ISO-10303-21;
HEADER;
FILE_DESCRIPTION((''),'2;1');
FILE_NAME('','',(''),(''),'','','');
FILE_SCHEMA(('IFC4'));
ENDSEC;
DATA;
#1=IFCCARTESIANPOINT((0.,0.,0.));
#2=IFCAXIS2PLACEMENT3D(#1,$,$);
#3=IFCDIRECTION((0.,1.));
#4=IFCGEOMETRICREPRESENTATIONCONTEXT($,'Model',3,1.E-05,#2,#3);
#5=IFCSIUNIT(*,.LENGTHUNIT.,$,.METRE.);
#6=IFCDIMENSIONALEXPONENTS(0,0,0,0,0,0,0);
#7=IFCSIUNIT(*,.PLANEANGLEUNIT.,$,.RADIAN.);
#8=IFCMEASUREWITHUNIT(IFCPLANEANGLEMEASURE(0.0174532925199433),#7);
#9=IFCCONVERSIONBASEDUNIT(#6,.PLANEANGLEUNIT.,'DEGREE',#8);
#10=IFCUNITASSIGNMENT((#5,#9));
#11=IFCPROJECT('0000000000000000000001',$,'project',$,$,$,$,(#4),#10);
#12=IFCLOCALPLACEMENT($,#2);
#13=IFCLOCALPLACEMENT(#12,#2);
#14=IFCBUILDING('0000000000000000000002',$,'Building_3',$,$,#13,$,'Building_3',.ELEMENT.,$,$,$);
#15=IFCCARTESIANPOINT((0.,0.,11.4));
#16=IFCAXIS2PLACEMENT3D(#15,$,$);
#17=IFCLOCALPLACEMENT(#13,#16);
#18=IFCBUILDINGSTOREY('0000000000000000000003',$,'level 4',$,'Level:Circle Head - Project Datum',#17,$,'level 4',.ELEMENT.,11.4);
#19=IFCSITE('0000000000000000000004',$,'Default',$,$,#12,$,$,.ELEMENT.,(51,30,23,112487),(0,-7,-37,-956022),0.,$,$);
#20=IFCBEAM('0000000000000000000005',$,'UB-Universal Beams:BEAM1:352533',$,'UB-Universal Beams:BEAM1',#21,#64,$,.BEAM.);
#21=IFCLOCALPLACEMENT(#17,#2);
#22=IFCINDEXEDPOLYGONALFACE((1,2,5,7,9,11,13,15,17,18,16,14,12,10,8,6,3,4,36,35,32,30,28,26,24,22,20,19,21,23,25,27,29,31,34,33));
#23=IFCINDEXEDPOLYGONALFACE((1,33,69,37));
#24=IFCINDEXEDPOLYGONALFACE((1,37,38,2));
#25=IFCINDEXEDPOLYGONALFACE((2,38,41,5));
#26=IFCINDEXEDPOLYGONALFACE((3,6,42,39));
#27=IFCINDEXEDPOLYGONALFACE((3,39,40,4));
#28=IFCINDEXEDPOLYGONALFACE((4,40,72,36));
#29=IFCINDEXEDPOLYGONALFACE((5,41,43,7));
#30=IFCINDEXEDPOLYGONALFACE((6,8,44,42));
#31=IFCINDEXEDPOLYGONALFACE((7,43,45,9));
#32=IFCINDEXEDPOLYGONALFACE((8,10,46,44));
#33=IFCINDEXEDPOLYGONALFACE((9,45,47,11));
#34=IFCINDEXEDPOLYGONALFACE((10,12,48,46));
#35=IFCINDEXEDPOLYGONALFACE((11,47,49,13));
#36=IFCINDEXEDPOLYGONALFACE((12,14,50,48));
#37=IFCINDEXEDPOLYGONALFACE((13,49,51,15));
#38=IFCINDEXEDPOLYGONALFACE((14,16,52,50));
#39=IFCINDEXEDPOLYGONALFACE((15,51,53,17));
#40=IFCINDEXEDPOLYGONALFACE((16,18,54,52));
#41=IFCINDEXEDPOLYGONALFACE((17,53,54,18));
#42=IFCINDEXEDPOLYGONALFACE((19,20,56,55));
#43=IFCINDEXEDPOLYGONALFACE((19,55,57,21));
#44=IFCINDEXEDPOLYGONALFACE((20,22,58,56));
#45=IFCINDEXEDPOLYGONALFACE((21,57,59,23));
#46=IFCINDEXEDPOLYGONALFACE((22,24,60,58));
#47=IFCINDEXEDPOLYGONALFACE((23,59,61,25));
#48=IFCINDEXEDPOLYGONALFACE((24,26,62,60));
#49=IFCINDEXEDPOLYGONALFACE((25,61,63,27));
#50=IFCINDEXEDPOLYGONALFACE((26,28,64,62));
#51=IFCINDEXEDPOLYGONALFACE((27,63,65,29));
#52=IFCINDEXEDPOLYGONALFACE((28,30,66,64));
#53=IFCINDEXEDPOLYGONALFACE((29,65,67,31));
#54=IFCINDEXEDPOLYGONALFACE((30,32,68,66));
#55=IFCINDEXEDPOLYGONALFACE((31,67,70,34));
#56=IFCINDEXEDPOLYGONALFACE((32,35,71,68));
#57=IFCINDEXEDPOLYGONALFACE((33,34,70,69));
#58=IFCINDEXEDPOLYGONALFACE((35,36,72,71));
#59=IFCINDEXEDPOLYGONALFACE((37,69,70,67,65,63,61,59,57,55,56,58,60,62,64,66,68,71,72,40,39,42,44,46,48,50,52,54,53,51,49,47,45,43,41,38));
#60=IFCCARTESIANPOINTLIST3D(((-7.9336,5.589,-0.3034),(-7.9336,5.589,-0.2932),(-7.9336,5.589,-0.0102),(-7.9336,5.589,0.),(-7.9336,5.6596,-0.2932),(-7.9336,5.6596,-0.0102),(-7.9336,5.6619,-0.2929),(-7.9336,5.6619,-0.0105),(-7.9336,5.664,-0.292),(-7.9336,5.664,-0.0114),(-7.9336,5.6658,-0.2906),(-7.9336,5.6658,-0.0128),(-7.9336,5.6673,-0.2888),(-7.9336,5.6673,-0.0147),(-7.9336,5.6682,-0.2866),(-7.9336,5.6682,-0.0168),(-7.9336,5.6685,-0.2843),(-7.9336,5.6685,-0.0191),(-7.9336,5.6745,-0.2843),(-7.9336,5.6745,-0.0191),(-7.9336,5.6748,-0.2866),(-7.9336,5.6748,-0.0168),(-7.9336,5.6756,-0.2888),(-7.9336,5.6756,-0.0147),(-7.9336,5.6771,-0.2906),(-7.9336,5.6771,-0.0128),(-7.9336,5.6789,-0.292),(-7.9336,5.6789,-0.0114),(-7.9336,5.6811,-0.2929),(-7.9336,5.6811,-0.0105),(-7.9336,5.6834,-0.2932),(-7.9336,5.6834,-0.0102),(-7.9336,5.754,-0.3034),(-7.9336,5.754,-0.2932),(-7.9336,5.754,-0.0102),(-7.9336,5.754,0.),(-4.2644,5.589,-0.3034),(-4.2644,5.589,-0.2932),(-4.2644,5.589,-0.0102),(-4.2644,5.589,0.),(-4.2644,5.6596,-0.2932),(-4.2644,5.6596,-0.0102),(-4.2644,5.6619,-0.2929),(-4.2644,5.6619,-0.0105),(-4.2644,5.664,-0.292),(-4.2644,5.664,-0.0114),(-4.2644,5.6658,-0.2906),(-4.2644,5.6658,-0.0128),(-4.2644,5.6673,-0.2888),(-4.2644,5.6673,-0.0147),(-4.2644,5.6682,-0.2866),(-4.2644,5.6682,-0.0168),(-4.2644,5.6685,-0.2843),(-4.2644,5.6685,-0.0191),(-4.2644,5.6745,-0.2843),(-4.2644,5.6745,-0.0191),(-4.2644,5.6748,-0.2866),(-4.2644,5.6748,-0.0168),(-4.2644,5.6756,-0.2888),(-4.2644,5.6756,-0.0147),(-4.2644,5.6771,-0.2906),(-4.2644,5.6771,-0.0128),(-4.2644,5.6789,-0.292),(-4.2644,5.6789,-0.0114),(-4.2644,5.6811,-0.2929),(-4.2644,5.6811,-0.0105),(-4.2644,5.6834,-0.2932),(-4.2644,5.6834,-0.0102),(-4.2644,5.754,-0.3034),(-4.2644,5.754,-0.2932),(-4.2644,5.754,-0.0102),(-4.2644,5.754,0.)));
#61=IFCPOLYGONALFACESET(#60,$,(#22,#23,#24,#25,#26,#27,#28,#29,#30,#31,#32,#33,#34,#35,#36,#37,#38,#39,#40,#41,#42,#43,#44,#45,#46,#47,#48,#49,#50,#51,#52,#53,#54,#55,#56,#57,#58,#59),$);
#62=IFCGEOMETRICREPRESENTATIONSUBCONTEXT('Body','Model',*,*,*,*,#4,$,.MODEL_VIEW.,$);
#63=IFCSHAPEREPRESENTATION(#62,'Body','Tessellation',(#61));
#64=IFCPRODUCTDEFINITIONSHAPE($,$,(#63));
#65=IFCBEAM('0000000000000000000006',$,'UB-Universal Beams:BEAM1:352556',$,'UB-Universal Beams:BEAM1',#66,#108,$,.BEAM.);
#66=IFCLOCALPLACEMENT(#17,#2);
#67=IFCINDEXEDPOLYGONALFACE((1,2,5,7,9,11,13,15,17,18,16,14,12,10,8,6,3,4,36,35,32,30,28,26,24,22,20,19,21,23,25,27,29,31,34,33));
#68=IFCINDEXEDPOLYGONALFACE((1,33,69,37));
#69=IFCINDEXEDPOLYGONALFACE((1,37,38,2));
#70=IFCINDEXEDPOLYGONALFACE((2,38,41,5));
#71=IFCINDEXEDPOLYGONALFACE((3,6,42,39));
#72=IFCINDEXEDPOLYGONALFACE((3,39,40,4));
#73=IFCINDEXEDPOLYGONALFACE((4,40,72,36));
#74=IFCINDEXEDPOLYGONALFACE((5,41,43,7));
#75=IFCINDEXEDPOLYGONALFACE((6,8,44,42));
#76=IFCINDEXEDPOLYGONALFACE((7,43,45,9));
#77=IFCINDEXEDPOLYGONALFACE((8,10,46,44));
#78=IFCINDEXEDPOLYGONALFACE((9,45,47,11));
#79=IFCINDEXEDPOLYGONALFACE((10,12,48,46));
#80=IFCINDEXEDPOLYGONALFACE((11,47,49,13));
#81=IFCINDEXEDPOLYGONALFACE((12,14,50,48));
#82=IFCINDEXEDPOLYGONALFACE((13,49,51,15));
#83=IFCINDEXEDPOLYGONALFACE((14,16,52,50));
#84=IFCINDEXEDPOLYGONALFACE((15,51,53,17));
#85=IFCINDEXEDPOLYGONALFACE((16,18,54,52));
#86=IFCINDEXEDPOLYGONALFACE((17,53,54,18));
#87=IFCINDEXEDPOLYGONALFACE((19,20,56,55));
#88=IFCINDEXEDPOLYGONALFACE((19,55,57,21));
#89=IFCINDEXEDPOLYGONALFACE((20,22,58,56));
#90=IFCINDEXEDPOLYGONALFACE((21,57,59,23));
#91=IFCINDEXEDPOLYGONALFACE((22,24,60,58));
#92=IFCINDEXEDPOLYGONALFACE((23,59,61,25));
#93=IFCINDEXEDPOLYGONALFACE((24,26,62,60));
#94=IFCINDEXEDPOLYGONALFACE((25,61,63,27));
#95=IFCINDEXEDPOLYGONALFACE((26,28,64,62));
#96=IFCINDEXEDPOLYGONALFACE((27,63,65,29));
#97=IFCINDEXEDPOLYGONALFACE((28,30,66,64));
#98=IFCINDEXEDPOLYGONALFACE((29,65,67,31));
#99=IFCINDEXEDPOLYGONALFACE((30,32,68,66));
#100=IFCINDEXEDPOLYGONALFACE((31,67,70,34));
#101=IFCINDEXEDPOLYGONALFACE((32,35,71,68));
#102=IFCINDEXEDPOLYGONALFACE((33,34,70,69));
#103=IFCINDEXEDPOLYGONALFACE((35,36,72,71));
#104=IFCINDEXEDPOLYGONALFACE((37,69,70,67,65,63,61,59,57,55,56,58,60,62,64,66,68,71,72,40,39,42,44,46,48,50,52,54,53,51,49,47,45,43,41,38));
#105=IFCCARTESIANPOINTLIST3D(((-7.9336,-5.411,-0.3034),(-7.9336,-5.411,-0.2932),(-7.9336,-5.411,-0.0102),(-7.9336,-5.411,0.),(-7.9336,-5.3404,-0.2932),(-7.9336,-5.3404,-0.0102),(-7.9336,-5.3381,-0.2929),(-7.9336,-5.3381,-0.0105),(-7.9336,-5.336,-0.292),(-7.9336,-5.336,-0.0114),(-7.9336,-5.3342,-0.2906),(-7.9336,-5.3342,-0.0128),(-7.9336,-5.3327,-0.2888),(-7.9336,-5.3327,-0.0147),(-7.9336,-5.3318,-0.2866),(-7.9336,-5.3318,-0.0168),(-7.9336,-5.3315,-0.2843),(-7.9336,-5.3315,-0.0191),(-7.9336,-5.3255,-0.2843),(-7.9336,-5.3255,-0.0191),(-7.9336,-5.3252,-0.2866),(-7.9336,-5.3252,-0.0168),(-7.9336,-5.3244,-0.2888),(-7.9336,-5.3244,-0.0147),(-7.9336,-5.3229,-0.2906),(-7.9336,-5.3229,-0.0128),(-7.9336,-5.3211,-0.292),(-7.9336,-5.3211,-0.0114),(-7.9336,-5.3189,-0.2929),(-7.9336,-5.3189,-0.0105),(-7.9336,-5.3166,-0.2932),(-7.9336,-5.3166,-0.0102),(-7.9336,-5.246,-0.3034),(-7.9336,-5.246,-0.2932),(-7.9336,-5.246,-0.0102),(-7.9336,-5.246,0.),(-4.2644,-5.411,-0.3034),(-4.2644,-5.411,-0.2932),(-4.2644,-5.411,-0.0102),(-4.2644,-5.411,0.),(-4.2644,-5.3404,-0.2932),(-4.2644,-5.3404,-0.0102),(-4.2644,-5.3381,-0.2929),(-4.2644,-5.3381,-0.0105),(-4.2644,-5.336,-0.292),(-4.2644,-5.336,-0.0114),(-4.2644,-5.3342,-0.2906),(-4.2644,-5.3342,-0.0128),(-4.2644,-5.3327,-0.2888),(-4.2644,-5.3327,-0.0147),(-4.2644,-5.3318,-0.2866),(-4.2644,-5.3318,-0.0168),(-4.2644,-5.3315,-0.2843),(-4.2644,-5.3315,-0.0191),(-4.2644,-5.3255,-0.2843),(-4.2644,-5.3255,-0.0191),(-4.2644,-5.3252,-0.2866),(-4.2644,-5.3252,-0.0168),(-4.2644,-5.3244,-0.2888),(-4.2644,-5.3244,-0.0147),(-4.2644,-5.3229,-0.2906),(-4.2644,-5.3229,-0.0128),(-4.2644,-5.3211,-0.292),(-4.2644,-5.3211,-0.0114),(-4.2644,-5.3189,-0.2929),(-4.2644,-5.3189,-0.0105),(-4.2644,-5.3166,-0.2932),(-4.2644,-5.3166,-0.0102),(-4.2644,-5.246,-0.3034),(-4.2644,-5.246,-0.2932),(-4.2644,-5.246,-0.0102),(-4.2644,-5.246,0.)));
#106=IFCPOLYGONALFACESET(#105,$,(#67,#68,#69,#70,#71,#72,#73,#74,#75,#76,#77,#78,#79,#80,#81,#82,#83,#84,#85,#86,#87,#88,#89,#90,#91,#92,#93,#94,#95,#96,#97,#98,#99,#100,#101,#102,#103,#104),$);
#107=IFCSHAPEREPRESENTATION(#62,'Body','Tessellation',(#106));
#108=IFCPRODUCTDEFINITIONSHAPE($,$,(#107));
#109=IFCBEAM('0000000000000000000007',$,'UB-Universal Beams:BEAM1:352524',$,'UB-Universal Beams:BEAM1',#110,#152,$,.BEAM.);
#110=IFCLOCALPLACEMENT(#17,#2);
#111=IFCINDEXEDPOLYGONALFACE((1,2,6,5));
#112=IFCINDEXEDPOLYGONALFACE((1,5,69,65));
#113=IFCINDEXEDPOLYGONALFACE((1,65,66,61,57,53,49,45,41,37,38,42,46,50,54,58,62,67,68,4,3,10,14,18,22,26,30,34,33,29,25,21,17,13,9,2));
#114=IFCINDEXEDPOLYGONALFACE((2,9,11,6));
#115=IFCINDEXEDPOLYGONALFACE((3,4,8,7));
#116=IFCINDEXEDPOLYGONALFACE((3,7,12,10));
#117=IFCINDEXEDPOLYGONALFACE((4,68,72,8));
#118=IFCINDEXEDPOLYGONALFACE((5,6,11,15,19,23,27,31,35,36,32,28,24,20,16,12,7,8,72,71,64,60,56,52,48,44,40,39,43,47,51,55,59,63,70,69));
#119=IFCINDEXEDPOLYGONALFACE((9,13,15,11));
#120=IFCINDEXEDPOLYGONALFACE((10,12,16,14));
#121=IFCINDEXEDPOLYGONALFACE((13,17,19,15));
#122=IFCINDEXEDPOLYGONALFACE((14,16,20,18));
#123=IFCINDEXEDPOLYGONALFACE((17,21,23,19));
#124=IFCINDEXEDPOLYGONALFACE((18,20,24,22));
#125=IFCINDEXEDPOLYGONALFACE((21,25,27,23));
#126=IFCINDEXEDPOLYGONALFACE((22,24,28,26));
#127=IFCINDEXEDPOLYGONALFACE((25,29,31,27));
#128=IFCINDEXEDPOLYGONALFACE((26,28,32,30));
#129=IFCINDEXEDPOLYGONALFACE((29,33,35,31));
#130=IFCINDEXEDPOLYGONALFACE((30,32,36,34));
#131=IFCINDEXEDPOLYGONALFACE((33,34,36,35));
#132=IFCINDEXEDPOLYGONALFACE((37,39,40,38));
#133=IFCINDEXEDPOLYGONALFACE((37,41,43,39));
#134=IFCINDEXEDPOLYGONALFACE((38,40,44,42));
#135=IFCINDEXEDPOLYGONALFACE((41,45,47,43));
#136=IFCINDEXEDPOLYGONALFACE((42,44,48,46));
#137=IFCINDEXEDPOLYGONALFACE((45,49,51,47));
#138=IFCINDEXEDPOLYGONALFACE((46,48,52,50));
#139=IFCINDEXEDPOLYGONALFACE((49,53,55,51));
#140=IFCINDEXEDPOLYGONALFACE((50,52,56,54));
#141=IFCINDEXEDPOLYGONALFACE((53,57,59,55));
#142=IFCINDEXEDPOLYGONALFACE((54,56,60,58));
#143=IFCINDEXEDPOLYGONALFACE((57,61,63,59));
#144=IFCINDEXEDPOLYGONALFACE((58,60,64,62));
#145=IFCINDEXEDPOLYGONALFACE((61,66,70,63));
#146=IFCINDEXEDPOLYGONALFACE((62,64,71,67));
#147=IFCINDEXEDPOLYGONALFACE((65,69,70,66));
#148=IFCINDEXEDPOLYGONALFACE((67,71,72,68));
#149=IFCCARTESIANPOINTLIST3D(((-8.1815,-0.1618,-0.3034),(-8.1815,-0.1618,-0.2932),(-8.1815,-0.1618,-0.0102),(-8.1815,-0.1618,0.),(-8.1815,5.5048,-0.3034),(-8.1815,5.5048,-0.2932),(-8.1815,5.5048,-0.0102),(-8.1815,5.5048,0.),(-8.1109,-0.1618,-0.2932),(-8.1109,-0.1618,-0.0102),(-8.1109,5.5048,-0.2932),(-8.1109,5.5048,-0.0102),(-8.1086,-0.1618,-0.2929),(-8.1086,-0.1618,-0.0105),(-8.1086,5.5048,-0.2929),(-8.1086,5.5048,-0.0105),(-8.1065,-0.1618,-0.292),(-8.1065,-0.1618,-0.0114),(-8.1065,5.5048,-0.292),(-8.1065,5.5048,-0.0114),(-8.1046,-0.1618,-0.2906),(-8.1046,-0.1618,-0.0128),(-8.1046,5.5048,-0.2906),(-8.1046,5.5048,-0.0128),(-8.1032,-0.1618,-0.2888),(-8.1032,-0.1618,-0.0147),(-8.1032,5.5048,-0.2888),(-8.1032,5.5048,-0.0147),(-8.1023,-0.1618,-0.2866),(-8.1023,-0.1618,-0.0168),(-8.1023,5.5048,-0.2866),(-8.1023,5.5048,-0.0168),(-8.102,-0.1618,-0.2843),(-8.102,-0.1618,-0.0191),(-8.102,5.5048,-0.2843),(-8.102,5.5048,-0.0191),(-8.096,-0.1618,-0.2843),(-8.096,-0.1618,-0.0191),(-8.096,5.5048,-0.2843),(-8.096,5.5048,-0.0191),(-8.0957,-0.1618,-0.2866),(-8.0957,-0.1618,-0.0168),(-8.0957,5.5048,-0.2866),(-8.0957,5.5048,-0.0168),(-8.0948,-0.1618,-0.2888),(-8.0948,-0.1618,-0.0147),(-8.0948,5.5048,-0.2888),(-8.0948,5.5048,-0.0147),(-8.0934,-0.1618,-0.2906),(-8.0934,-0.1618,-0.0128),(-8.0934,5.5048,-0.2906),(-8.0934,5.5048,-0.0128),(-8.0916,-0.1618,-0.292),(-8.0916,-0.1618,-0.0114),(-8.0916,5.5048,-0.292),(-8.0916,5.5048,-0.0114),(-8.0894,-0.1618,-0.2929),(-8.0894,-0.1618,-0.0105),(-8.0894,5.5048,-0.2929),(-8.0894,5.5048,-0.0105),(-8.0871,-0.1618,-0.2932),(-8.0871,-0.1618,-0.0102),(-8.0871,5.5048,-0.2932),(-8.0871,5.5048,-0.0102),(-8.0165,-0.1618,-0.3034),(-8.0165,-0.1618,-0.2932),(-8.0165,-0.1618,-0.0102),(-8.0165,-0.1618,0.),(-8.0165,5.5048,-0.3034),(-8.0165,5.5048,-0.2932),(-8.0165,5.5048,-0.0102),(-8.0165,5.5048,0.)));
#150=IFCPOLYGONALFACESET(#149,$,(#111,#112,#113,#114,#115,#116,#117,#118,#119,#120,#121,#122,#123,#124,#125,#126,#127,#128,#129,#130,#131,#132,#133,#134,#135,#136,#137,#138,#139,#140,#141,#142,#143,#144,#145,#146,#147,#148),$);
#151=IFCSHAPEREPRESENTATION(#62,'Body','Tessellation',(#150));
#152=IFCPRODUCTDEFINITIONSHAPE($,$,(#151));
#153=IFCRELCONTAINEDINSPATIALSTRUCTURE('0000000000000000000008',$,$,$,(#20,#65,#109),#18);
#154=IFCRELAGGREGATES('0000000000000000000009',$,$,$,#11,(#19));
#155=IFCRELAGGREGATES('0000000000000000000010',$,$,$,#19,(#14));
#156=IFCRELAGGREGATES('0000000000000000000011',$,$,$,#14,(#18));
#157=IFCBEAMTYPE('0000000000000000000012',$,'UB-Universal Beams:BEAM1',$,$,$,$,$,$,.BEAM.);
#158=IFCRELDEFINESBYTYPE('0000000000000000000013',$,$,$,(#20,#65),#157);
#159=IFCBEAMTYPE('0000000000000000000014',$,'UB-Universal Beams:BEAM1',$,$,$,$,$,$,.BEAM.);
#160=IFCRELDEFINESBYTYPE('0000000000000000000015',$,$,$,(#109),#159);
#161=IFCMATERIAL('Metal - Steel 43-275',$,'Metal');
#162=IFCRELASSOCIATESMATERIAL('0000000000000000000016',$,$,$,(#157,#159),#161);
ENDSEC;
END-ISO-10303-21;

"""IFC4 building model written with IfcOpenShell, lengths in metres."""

from ifc_helpers import new_model, entity, si_unit, converted_unit, direction, frame, frame_2d, origin, place, context, subcontext, project, spatial, polyline, circle_curve, parameter, trimmed, segment, composite_curve, outline, extrude, source, transform, mapped, material, material_profile, profile_set, type_object, type_shapes, element, save


model = new_model("IFC4")

# Units and contexts
model_context = context("Model", 3, precision=1e-05, world=origin(), true_north=direction((0.0, 1.0)))
body_context = subcontext(model_context, "Body", "Model", "MODEL_VIEW")
ifc_project = project(units=[si_unit("LENGTHUNIT", "METRE"), converted_unit("PLANEANGLEUNIT", "DEGREE", entity("IfcPlaneAngleMeasure", 0.0174532925199433), si_unit("PLANEANGLEUNIT", "RADIAN"), dimensions=[0, 0, 0, 0, 0, 0, 0])], contexts=[model_context])

# Site, building, storey
site_placement = place(None, origin())
site = spatial("IfcSite", under=ifc_project, at=site_placement, Name="Default", CompositionType="ELEMENT", RefLatitude=(51, 30, 23, 112487), RefLongitude=(0, -7, -37, -956022), RefElevation=0.0)
building_placement = place(site_placement, origin())
building = spatial("IfcBuilding", under=site, at=building_placement, Name="Building_3", LongName="Building_3", CompositionType="ELEMENT")
storey_placement = place(building_placement, frame((0.0, 0.0, 11.4)))
storey = spatial("IfcBuildingStorey", under=building, at=storey_placement, Name="level 4", ObjectType="Level:Circle Head - Project Datum", LongName="level 4", CompositionType="ELEMENT", Elevation=11.4)

# Shared definitions
ifc_material_1 = material(Name="Metal - Steel 43-275", Category="Metal")

# Beams
ifc_material_profile_1 = material_profile(ifc_material_1, outline(composite_curve([segment(polyline([(-0.0825, -0.1415), (-0.0825, -0.1517)]), True, "CONTINUOUS"), segment(polyline([(-0.0825, -0.1517), (0.0825, -0.1517)]), True, "CONTINUOUS"), segment(polyline([(0.0825, -0.1517), (0.0825, -0.1415)]), True, "CONTINUOUS"), segment(polyline([(0.0825, -0.1415), (0.0119, -0.1415)]), True, "CONTINUOUS"), segment(trimmed(circle_curve(frame_2d((0.0119, -0.1326), x_axis=(1.0, 0.0)), 0.0089), [parameter(180.0)], [parameter(270.0)], True, "PARAMETER"), False, "CONTINUOUS"), segment(polyline([(0.003, -0.1326), (0.003, 0.1326)]), True, "CONTINUOUS"), segment(trimmed(circle_curve(frame_2d((0.0119, 0.1326), x_axis=(1.0, 0.0)), 0.0089), [parameter(90.0)], [parameter(180.0)], True, "PARAMETER"), False, "CONTINUOUS"), segment(polyline([(0.0119, 0.1415), (0.0825, 0.1415)]), True, "CONTINUOUS"), segment(polyline([(0.0825, 0.1415), (0.0825, 0.1517)]), True, "CONTINUOUS"), segment(polyline([(0.0825, 0.1517), (-0.0825, 0.1517)]), True, "CONTINUOUS"), segment(polyline([(-0.0825, 0.1517), (-0.0825, 0.1415)]), True, "CONTINUOUS"), segment(polyline([(-0.0825, 0.1415), (-0.0119, 0.1415)]), True, "CONTINUOUS"), segment(trimmed(circle_curve(frame_2d((-0.0119, 0.1326), x_axis=(1.0, 0.0)), 0.0089), [parameter(360.0)], [parameter(90.0)], True, "PARAMETER"), False, "CONTINUOUS"), segment(polyline([(-0.003, 0.1326), (-0.003, -0.1326)]), True, "CONTINUOUS"), segment(trimmed(circle_curve(frame_2d((-0.0119, -0.1326), x_axis=(1.0, 0.0)), 0.0089), [parameter(270.0)], [parameter(360.0)], True, "PARAMETER"), False, "CONTINUOUS"), segment(polyline([(-0.0119, -0.1415), (-0.0825, -0.1415)]), True, "CONTINUOUS")], self_intersect=False)), Name="BEAM1")
ifc_profile_set_1 = profile_set([ifc_material_profile_1], Name="BEAM1")
beam_type_1 = type_object("IfcBeamType", Name="UB-Universal Beams:BEAM1", PredefinedType="BEAM", material=ifc_profile_set_1)
shared_shape_1 = source(origin(), body_context, "Body", "SweptSolid", [
    extrude(outline(composite_curve([segment(polyline([(-0.0825, -0.1415), (-0.0825, -0.1517)]), True, "CONTINUOUS"), segment(polyline([(-0.0825, -0.1517), (0.0825, -0.1517)]), True, "CONTINUOUS"), segment(polyline([(0.0825, -0.1517), (0.0825, -0.1415)]), True, "CONTINUOUS"), segment(polyline([(0.0825, -0.1415), (0.0119, -0.1415)]), True, "CONTINUOUS"), segment(trimmed(circle_curve(frame_2d((0.0119, -0.1326), x_axis=(0.0, -1.0)), 0.0089), [parameter(270.0)], [parameter(360.0)], True, "PARAMETER"), False, "CONTINUOUS"), segment(polyline([(0.003, -0.1326), (0.003, 0.1326)]), True, "CONTINUOUS"), segment(trimmed(circle_curve(frame_2d((0.0119, 0.1326), x_axis=(-1.0, 0.0)), 0.0089), [parameter(270.0)], [parameter(360.0)], True, "PARAMETER"), False, "CONTINUOUS"), segment(polyline([(0.0119, 0.1415), (0.0825, 0.1415)]), True, "CONTINUOUS"), segment(polyline([(0.0825, 0.1415), (0.0825, 0.1517)]), True, "CONTINUOUS"), segment(polyline([(0.0825, 0.1517), (-0.0825, 0.1517)]), True, "CONTINUOUS"), segment(polyline([(-0.0825, 0.1517), (-0.0825, 0.1415)]), True, "CONTINUOUS"), segment(polyline([(-0.0825, 0.1415), (-0.0119, 0.1415)]), True, "CONTINUOUS"), segment(trimmed(circle_curve(frame_2d((-0.0119, 0.1326), x_axis=(0.0, 1.0)), 0.0089), [parameter(270.0)], [parameter(360.0)], True, "PARAMETER"), False, "CONTINUOUS"), segment(polyline([(-0.003, 0.1326), (-0.003, -0.1326)]), True, "CONTINUOUS"), segment(trimmed(circle_curve(frame_2d((-0.0119, -0.1326), x_axis=(1.0, 0.0)), 0.0089), [parameter(270.0)], [parameter(0.0)], True, "PARAMETER"), False, "CONTINUOUS"), segment(polyline([(-0.0119, -0.1415), (-0.0825, -0.1415)]), True, "CONTINUOUS")], self_intersect=False)), frame((-1.8346, 0.0, 0.0), z_axis=(-1.0, 0.0, 0.0), x_axis=(0.0, -1.0, 0.0)), (0.0, 0.0, -1.0), 3.6692),
])
type_shapes(beam_type_1, [shared_shape_1])
for number, where, name in (
    (1, (-6.099, 5.6715, -0.1517), "UB-Universal Beams:BEAM1:352533"),
    (2, (-6.099, -5.3285, -0.1517), "UB-Universal Beams:BEAM1:352556"),
):
    element("IfcBeam", number, at=place(storey_placement, frame(where)), inside=storey, type_object=beam_type_1, Name=name, ObjectType="UB-Universal Beams:BEAM1", PredefinedType="BEAM", context=body_context, shape_type="MappedRepresentation", body=[
        mapped(shared_shape_1, transform((0.0, 0.0, 0.0), scale=1.0)),
    ])
beam_type_2 = type_object("IfcBeamType", Name="UB-Universal Beams:BEAM1", PredefinedType="BEAM", material=ifc_profile_set_1)
shared_shape_2 = source(origin(), body_context, "Body", "SweptSolid", [
    extrude(outline(composite_curve([segment(polyline([(-0.0825, -0.1415), (-0.0825, -0.1517)]), True, "CONTINUOUS"), segment(polyline([(-0.0825, -0.1517), (0.0825, -0.1517)]), True, "CONTINUOUS"), segment(polyline([(0.0825, -0.1517), (0.0825, -0.1415)]), True, "CONTINUOUS"), segment(polyline([(0.0825, -0.1415), (0.0119, -0.1415)]), True, "CONTINUOUS"), segment(trimmed(circle_curve(frame_2d((0.0119, -0.1326), x_axis=(1.0, 0.0)), 0.0089), [parameter(180.0)], [parameter(270.0)], True, "PARAMETER"), False, "CONTINUOUS"), segment(polyline([(0.003, -0.1326), (0.003, 0.1326)]), True, "CONTINUOUS"), segment(trimmed(circle_curve(frame_2d((0.0119, 0.1326), x_axis=(1.0, 0.0)), 0.0089), [parameter(90.0)], [parameter(180.0)], True, "PARAMETER"), False, "CONTINUOUS"), segment(polyline([(0.0119, 0.1415), (0.0825, 0.1415)]), True, "CONTINUOUS"), segment(polyline([(0.0825, 0.1415), (0.0825, 0.1517)]), True, "CONTINUOUS"), segment(polyline([(0.0825, 0.1517), (-0.0825, 0.1517)]), True, "CONTINUOUS"), segment(polyline([(-0.0825, 0.1517), (-0.0825, 0.1415)]), True, "CONTINUOUS"), segment(polyline([(-0.0825, 0.1415), (-0.0119, 0.1415)]), True, "CONTINUOUS"), segment(trimmed(circle_curve(frame_2d((-0.0119, 0.1326), x_axis=(1.0, 0.0)), 0.0089), [parameter(360.0)], [parameter(90.0)], True, "PARAMETER"), False, "CONTINUOUS"), segment(polyline([(-0.003, 0.1326), (-0.003, -0.1326)]), True, "CONTINUOUS"), segment(trimmed(circle_curve(frame_2d((-0.0119, -0.1326), x_axis=(1.0, 0.0)), 0.0089), [parameter(270.0)], [parameter(360.0)], True, "PARAMETER"), False, "CONTINUOUS"), segment(polyline([(-0.0119, -0.1415), (-0.0825, -0.1415)]), True, "CONTINUOUS")], self_intersect=False)), frame((-2.8333, 0.0, 0.0), z_axis=(-1.0, 0.0, 0.0), x_axis=(0.0, -1.0, 0.0)), (0.0, 0.0, -1.0), 5.6666),
])
type_shapes(beam_type_2, [shared_shape_2])
for number, where, z_axis, x_axis, name in (
    (3, (-8.099, 2.6715, -0.1517), (0.0, 0.0, 1.0), (0.0, -1.0, 0.0), "UB-Universal Beams:BEAM1:352524"),
):
    element("IfcBeam", number, at=place(storey_placement, frame(where, z_axis=z_axis, x_axis=x_axis)), inside=storey, type_object=beam_type_2, Name=name, ObjectType="UB-Universal Beams:BEAM1", PredefinedType="BEAM", context=body_context, shape_type="MappedRepresentation", body=[
        mapped(shared_shape_2, transform((0.0, 0.0, 0.0), scale=1.0)),
    ])

save(model, "model.ifc")
